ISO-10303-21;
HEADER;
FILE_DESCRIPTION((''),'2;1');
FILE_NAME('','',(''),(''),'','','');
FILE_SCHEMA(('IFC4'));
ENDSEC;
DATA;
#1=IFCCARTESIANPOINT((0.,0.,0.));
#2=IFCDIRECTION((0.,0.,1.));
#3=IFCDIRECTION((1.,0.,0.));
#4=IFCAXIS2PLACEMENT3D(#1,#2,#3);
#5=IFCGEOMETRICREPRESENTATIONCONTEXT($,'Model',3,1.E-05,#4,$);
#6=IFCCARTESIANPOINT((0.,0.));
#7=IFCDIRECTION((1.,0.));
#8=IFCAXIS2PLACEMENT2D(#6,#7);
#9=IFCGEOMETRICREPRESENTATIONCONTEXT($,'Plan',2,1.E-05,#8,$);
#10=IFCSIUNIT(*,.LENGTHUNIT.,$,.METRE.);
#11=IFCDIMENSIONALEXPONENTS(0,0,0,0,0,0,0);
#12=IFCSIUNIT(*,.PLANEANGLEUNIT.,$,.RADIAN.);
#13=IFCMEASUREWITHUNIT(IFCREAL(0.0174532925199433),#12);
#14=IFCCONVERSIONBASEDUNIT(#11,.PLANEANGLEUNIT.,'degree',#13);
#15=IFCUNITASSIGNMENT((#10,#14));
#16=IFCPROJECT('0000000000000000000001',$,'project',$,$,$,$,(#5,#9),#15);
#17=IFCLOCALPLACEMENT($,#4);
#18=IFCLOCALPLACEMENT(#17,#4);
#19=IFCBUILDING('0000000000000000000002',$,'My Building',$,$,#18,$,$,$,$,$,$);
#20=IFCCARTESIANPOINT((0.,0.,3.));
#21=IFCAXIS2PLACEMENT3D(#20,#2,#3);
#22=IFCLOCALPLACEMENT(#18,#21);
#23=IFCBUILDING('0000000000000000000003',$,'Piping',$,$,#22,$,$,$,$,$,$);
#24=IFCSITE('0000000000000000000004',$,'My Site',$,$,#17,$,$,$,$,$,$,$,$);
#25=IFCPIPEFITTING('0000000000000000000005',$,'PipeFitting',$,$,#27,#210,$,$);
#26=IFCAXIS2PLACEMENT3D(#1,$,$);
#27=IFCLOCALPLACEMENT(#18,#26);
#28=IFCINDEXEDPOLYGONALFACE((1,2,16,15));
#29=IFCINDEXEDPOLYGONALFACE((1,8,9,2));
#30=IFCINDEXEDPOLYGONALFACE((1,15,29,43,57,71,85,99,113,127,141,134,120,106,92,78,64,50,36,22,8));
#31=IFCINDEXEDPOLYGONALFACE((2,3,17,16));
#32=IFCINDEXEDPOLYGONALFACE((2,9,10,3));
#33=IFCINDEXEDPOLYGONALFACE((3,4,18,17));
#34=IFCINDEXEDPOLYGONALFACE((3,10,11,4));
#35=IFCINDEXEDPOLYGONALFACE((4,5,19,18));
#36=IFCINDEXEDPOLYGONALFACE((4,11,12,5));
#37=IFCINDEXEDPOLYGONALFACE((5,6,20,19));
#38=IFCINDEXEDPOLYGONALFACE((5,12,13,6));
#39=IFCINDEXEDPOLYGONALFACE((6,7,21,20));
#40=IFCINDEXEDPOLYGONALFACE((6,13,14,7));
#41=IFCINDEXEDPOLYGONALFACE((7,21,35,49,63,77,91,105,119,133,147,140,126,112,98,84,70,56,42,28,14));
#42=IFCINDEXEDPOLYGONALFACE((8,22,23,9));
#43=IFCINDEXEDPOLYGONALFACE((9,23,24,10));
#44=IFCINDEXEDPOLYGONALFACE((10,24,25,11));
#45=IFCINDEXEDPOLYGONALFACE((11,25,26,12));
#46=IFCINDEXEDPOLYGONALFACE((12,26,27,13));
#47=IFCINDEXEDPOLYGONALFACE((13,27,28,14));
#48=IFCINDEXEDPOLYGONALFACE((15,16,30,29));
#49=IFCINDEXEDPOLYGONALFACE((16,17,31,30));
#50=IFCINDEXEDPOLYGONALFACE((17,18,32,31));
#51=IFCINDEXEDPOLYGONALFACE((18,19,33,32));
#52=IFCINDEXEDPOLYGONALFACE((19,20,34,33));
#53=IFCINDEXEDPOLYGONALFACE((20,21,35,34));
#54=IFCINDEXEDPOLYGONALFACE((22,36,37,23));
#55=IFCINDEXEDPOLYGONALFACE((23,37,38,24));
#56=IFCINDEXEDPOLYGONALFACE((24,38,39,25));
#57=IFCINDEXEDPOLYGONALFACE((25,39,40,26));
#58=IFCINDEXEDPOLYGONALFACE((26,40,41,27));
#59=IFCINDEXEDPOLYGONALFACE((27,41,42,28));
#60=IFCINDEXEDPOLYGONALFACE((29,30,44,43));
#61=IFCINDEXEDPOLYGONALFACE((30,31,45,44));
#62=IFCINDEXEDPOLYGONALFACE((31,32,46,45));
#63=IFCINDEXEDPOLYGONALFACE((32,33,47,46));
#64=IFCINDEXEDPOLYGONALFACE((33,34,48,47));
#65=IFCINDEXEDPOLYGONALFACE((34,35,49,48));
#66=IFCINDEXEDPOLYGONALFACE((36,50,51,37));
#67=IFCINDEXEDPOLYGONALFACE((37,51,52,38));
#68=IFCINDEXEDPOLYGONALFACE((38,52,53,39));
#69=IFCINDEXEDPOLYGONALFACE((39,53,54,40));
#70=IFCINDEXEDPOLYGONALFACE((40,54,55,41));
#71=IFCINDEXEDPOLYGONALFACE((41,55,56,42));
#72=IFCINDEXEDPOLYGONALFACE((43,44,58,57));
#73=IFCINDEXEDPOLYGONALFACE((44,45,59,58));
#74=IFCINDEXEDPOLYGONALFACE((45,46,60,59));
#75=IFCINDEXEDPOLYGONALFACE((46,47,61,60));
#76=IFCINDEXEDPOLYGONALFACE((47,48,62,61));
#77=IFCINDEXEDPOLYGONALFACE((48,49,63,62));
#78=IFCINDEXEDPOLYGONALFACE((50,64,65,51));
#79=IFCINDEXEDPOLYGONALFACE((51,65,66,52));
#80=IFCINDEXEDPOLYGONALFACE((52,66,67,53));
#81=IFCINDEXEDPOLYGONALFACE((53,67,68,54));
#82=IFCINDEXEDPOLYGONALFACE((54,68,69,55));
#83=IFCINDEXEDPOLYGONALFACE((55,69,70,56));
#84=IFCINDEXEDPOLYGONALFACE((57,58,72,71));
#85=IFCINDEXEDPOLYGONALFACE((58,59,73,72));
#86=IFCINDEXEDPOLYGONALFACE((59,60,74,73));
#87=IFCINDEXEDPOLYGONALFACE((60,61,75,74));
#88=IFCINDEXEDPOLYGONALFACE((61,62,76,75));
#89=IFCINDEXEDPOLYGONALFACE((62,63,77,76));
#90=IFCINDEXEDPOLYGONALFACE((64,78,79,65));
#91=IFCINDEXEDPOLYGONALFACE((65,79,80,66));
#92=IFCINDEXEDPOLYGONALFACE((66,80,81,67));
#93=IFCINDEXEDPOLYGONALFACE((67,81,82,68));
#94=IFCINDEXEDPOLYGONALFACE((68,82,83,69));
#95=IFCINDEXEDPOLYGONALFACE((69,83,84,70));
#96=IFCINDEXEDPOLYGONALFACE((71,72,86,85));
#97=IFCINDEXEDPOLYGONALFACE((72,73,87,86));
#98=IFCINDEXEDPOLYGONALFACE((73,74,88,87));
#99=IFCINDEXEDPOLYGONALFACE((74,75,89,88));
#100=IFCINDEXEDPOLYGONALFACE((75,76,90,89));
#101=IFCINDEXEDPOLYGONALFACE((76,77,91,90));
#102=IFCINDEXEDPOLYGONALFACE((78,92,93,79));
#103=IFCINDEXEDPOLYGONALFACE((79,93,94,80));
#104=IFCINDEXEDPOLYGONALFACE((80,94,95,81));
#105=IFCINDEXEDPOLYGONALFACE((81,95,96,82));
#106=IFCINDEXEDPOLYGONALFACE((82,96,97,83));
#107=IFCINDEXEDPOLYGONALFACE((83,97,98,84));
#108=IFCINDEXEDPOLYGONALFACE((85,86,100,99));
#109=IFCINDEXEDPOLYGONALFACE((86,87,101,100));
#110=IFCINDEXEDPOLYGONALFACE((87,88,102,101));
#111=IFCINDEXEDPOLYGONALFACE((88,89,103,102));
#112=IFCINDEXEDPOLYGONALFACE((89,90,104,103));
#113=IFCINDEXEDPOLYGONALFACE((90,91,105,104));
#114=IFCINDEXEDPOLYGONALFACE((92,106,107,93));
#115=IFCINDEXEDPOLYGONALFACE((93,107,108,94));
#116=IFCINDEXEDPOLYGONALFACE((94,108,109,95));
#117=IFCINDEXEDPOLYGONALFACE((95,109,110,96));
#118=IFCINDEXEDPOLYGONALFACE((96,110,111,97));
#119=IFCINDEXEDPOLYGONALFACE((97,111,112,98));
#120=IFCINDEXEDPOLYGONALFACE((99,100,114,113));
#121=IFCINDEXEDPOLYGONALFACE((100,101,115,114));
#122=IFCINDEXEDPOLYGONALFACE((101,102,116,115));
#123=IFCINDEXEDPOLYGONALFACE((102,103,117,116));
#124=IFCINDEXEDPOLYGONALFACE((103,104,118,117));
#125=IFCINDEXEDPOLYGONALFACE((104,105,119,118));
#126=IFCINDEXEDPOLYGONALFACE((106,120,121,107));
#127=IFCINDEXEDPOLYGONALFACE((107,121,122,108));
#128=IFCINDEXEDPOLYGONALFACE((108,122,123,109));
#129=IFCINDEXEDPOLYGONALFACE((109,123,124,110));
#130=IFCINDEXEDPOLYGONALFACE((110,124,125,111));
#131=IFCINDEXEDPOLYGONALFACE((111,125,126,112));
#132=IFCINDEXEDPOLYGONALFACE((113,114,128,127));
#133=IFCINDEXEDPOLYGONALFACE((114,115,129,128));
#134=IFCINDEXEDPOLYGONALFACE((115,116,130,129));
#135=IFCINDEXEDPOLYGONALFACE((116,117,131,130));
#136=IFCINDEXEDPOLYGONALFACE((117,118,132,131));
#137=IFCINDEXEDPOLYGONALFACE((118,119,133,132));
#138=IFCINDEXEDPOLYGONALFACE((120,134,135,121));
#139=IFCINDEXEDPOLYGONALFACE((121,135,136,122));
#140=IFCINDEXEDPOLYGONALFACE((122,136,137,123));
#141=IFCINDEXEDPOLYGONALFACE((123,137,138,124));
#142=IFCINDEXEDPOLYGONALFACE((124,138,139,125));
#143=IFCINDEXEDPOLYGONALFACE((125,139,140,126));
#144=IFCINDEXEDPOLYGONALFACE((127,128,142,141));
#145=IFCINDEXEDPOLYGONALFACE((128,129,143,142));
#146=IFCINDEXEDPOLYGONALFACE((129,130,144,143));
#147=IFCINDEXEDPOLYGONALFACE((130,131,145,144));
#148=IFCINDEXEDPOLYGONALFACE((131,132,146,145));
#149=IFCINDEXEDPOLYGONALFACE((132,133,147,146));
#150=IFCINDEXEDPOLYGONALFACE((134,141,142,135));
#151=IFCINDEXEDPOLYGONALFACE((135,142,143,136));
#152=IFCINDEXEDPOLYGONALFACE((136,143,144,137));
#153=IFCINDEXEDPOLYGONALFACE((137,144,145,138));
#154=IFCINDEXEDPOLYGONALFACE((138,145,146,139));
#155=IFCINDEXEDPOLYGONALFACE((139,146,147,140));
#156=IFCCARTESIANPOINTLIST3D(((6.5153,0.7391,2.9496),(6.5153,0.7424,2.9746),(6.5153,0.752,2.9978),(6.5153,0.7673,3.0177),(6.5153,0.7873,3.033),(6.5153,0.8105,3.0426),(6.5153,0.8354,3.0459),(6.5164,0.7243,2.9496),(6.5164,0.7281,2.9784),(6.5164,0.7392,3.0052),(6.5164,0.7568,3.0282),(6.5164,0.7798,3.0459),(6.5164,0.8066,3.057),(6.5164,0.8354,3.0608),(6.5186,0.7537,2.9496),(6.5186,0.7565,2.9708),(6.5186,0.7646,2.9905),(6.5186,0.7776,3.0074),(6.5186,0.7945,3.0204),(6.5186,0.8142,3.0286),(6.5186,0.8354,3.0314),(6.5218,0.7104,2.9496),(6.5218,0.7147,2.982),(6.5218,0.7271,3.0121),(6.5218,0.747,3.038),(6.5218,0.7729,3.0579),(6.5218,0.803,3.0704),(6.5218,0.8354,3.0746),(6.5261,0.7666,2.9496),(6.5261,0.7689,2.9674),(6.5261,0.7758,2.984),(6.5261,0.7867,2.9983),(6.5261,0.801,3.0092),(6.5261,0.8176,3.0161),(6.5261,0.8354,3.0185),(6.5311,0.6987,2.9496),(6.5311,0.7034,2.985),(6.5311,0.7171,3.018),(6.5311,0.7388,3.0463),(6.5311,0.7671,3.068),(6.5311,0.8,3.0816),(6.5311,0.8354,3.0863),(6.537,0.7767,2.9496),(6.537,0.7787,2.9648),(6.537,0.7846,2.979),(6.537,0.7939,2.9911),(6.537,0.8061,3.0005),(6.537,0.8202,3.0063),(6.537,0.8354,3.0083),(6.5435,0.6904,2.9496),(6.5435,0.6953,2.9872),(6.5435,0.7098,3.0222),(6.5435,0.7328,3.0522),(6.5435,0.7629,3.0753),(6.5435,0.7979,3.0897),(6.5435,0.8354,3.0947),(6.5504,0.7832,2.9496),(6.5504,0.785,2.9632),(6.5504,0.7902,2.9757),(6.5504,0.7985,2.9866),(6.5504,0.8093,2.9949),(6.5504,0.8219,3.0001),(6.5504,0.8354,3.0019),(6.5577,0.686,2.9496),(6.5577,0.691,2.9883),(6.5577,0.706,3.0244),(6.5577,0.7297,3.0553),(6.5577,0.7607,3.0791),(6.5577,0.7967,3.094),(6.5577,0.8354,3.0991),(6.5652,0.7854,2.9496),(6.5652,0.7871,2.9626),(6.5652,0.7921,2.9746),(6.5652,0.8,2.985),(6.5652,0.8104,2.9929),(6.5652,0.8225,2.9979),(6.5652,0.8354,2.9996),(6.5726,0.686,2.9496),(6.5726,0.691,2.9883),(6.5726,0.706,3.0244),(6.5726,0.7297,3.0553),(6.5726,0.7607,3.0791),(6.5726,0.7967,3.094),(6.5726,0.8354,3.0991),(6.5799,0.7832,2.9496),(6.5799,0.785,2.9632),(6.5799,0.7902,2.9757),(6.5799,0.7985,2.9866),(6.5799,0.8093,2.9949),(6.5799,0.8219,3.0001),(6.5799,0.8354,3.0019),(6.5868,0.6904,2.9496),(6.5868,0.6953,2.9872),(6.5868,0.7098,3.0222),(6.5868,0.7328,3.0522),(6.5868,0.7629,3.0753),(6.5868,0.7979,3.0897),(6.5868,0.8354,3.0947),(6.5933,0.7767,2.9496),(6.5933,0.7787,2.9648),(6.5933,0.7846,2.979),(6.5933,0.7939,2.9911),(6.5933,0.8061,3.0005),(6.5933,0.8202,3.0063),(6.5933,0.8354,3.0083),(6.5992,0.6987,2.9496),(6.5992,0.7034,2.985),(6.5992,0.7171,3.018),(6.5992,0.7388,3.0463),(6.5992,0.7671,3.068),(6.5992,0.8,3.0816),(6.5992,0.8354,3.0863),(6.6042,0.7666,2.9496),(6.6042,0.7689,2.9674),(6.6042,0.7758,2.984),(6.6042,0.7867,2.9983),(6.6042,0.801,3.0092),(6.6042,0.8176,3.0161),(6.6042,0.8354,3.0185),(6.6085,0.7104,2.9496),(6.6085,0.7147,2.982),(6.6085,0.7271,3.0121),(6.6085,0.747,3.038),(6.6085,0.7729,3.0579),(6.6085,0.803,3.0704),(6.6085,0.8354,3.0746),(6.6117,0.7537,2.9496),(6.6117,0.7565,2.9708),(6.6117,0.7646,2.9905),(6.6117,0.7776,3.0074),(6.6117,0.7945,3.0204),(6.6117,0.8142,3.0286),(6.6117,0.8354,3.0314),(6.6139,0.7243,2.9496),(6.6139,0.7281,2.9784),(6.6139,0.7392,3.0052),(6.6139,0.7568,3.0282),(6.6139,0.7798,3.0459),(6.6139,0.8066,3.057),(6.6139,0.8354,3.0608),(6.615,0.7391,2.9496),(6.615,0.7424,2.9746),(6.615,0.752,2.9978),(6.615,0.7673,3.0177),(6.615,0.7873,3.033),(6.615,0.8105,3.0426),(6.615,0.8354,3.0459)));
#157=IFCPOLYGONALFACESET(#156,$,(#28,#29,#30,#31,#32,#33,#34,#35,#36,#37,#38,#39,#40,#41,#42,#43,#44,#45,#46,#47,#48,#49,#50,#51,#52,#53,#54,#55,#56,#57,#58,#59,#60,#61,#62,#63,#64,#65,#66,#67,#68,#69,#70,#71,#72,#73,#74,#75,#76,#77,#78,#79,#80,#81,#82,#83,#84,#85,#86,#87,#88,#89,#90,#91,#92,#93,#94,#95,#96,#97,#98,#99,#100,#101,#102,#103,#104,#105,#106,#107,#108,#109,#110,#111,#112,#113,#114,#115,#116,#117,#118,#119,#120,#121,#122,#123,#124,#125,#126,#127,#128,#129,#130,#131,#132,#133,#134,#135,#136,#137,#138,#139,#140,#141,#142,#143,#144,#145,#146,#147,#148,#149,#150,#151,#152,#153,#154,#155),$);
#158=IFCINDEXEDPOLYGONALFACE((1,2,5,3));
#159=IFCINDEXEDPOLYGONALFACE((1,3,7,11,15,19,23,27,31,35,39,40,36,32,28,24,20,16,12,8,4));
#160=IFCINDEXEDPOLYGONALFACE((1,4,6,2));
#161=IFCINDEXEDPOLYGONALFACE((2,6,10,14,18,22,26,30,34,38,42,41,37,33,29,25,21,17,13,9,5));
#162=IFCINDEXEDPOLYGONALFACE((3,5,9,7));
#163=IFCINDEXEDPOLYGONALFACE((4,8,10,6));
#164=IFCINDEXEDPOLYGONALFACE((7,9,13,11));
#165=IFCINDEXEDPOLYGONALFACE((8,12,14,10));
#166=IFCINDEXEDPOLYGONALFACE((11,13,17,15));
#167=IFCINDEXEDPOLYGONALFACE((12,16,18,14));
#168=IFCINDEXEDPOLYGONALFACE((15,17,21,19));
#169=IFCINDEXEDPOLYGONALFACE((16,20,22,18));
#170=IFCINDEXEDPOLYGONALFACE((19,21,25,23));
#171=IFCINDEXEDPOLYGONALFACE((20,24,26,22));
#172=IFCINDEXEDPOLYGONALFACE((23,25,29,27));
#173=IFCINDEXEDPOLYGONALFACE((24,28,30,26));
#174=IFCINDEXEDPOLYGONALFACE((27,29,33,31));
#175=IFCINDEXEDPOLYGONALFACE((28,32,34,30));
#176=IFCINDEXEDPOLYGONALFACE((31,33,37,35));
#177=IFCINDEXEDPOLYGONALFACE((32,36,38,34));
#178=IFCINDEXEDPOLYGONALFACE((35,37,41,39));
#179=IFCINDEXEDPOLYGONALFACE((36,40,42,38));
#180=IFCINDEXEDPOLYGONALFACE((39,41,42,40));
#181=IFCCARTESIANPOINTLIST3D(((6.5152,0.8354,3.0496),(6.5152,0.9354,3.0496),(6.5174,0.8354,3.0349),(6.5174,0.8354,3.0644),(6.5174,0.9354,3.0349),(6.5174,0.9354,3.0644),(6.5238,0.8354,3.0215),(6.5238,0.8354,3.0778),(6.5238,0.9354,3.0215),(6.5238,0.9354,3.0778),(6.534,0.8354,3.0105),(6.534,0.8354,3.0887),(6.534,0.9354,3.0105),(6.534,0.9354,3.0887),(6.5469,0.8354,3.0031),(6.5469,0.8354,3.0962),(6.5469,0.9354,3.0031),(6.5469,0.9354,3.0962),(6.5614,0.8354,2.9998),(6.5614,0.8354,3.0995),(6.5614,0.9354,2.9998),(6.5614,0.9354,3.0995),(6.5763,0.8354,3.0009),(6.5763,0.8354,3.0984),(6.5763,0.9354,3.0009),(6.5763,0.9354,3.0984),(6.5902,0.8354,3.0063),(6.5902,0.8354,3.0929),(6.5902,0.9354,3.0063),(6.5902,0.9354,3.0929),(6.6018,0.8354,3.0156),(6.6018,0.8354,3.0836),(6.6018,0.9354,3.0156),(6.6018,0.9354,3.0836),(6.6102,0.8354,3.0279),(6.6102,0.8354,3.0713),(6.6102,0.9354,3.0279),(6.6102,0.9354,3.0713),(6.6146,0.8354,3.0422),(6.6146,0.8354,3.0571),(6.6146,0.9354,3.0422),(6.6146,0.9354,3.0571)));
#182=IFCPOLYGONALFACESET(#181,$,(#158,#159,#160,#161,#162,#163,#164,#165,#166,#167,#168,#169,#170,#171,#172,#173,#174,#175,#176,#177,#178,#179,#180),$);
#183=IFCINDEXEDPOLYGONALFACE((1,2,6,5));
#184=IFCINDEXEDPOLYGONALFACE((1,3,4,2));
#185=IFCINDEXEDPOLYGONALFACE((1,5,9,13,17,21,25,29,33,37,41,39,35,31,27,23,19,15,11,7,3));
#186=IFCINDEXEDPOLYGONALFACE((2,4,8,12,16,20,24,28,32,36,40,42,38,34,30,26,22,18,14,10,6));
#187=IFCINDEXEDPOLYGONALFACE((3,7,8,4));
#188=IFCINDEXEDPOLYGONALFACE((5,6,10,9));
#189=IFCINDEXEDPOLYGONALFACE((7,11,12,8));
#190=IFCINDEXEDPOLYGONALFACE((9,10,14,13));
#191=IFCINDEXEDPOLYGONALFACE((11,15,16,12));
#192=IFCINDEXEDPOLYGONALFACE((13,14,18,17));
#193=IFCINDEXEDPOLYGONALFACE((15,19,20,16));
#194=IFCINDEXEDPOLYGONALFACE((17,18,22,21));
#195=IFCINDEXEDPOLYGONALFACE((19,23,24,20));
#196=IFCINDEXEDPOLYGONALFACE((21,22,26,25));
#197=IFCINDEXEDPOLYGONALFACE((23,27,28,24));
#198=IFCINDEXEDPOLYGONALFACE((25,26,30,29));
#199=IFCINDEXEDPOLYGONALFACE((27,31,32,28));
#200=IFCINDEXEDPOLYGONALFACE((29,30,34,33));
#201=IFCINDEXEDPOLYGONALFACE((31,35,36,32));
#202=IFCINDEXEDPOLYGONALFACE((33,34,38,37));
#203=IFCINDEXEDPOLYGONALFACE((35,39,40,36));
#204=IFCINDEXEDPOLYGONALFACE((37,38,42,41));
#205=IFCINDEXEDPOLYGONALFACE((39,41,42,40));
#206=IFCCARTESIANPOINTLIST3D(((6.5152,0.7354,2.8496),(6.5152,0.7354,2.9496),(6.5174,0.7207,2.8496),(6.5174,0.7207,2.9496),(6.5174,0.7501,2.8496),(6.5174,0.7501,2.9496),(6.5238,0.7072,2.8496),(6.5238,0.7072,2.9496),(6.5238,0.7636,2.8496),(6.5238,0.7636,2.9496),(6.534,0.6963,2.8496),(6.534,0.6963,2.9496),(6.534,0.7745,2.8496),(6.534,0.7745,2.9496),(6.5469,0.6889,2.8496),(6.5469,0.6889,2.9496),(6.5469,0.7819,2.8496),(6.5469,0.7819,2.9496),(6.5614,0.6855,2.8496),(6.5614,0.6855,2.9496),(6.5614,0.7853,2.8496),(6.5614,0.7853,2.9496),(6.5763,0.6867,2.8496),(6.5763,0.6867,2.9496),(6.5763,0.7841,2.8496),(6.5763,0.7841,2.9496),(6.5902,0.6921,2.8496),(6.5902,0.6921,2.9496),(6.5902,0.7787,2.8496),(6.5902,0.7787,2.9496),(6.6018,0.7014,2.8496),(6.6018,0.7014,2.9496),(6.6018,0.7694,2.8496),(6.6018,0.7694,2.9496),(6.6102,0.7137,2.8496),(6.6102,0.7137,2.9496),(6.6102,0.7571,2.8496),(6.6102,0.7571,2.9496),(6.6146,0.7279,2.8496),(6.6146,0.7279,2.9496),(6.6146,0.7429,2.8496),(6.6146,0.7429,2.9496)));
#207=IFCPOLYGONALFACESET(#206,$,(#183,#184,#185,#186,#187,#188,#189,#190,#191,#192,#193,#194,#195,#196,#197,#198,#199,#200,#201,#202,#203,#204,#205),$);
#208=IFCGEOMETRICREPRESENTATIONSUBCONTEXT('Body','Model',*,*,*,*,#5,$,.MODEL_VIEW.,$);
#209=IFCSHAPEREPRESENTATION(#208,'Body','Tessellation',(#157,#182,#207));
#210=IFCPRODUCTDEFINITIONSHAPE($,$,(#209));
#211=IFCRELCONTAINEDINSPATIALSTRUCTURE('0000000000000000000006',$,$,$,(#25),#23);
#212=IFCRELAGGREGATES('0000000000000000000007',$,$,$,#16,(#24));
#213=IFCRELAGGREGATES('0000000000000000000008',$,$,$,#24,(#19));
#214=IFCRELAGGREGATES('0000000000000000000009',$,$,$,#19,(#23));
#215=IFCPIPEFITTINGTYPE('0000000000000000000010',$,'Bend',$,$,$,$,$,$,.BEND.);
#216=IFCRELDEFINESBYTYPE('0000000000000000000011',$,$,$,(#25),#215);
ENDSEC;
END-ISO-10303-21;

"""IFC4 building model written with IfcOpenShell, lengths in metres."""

from ifc_helpers import new_model, entity, si_unit, converted_unit, frame, origin_with_axes, origin_2d_with_axis, place, context, subcontext, project, spatial, circle, extrude, source, transform, mapped, type_object, type_shapes, element, save


model = new_model("IFC4")

# Units and contexts
model_context = context("Model", 3, precision=1e-05, world=origin_with_axes())
plan_context = context("Plan", 2, precision=1e-05, world=origin_2d_with_axis())
body_context = subcontext(model_context, "Body", "Model", "MODEL_VIEW")
ifc_project = project(units=[si_unit("LENGTHUNIT", "METRE"), converted_unit("PLANEANGLEUNIT", "degree", entity("IfcReal", 0.0174532925199433), si_unit("PLANEANGLEUNIT", "RADIAN"), dimensions=[0, 0, 0, 0, 0, 0, 0])], contexts=[model_context, plan_context])

# Site, buildings
site_placement = place(None, origin_with_axes())
site = spatial("IfcSite", under=ifc_project, at=site_placement, Name="My Site")
building_1_placement = place(site_placement, origin_with_axes())
building_1 = spatial("IfcBuilding", under=site, at=building_1_placement, Name="My Building")
building_2_placement = place(building_1_placement, frame((0.0, 0.0, 3.0), z_axis=(0.0, 0.0, 1.0), x_axis=(1.0, 0.0, 0.0)))
building_2 = spatial("IfcBuilding", under=building_1, at=building_2_placement, Name="Piping")

# Pipe fitting
pipe_fitting_type_1 = type_object("IfcPipeFittingType", Name="Bend", PredefinedType="BEND")
shared_shape = source(origin_with_axes(), body_context, "Body", "SolidModel", [
    entity("IfcSweptDiskSolid", entity("IfcIndexedPolyCurve", entity("IfcCartesianPointList3D", [[0.0, 0.0, 0.1], [0.0, 0.0293, 0.1707], [0.0, 0.1, 0.2]]), [entity("IfcArcIndex", [1, 2, 3])]), 0.05),
    extrude(circle(Radius=0.05), origin_with_axes(), (0.0, 0.0, 1.0), 0.1),
    extrude(circle(Radius=0.05), frame((0.0, 0.1, 0.2), z_axis=(0.0, 1.0, 0.0), x_axis=(1.0, 0.0, 0.0)), (0.0, 0.0, 1.0), 0.1),
])
type_shapes(pipe_fitting_type_1, [shared_shape])
for number, where, z_axis, x_axis, name in (
    (1, (6.5652, 0.9354, 0.0496), (0.0, -1.0, 0.0), (-1.0, 0.0, 0.0), "PipeFitting"),
):
    element("IfcPipeFitting", number, at=place(building_2_placement, frame(where, z_axis=z_axis, x_axis=x_axis)), inside=building_2, type_object=pipe_fitting_type_1, Name=name, context=body_context, shape_type="MappedRepresentation", body=[
        mapped(shared_shape, transform((0.0, 0.0, 0.0), x_axis=(1.0, 0.0, 0.0), y_axis=(0.0, 1.0, 0.0), z_axis=(0.0, 0.0, 1.0), scale=1.0)),
    ])

save(model, "model.ifc")
